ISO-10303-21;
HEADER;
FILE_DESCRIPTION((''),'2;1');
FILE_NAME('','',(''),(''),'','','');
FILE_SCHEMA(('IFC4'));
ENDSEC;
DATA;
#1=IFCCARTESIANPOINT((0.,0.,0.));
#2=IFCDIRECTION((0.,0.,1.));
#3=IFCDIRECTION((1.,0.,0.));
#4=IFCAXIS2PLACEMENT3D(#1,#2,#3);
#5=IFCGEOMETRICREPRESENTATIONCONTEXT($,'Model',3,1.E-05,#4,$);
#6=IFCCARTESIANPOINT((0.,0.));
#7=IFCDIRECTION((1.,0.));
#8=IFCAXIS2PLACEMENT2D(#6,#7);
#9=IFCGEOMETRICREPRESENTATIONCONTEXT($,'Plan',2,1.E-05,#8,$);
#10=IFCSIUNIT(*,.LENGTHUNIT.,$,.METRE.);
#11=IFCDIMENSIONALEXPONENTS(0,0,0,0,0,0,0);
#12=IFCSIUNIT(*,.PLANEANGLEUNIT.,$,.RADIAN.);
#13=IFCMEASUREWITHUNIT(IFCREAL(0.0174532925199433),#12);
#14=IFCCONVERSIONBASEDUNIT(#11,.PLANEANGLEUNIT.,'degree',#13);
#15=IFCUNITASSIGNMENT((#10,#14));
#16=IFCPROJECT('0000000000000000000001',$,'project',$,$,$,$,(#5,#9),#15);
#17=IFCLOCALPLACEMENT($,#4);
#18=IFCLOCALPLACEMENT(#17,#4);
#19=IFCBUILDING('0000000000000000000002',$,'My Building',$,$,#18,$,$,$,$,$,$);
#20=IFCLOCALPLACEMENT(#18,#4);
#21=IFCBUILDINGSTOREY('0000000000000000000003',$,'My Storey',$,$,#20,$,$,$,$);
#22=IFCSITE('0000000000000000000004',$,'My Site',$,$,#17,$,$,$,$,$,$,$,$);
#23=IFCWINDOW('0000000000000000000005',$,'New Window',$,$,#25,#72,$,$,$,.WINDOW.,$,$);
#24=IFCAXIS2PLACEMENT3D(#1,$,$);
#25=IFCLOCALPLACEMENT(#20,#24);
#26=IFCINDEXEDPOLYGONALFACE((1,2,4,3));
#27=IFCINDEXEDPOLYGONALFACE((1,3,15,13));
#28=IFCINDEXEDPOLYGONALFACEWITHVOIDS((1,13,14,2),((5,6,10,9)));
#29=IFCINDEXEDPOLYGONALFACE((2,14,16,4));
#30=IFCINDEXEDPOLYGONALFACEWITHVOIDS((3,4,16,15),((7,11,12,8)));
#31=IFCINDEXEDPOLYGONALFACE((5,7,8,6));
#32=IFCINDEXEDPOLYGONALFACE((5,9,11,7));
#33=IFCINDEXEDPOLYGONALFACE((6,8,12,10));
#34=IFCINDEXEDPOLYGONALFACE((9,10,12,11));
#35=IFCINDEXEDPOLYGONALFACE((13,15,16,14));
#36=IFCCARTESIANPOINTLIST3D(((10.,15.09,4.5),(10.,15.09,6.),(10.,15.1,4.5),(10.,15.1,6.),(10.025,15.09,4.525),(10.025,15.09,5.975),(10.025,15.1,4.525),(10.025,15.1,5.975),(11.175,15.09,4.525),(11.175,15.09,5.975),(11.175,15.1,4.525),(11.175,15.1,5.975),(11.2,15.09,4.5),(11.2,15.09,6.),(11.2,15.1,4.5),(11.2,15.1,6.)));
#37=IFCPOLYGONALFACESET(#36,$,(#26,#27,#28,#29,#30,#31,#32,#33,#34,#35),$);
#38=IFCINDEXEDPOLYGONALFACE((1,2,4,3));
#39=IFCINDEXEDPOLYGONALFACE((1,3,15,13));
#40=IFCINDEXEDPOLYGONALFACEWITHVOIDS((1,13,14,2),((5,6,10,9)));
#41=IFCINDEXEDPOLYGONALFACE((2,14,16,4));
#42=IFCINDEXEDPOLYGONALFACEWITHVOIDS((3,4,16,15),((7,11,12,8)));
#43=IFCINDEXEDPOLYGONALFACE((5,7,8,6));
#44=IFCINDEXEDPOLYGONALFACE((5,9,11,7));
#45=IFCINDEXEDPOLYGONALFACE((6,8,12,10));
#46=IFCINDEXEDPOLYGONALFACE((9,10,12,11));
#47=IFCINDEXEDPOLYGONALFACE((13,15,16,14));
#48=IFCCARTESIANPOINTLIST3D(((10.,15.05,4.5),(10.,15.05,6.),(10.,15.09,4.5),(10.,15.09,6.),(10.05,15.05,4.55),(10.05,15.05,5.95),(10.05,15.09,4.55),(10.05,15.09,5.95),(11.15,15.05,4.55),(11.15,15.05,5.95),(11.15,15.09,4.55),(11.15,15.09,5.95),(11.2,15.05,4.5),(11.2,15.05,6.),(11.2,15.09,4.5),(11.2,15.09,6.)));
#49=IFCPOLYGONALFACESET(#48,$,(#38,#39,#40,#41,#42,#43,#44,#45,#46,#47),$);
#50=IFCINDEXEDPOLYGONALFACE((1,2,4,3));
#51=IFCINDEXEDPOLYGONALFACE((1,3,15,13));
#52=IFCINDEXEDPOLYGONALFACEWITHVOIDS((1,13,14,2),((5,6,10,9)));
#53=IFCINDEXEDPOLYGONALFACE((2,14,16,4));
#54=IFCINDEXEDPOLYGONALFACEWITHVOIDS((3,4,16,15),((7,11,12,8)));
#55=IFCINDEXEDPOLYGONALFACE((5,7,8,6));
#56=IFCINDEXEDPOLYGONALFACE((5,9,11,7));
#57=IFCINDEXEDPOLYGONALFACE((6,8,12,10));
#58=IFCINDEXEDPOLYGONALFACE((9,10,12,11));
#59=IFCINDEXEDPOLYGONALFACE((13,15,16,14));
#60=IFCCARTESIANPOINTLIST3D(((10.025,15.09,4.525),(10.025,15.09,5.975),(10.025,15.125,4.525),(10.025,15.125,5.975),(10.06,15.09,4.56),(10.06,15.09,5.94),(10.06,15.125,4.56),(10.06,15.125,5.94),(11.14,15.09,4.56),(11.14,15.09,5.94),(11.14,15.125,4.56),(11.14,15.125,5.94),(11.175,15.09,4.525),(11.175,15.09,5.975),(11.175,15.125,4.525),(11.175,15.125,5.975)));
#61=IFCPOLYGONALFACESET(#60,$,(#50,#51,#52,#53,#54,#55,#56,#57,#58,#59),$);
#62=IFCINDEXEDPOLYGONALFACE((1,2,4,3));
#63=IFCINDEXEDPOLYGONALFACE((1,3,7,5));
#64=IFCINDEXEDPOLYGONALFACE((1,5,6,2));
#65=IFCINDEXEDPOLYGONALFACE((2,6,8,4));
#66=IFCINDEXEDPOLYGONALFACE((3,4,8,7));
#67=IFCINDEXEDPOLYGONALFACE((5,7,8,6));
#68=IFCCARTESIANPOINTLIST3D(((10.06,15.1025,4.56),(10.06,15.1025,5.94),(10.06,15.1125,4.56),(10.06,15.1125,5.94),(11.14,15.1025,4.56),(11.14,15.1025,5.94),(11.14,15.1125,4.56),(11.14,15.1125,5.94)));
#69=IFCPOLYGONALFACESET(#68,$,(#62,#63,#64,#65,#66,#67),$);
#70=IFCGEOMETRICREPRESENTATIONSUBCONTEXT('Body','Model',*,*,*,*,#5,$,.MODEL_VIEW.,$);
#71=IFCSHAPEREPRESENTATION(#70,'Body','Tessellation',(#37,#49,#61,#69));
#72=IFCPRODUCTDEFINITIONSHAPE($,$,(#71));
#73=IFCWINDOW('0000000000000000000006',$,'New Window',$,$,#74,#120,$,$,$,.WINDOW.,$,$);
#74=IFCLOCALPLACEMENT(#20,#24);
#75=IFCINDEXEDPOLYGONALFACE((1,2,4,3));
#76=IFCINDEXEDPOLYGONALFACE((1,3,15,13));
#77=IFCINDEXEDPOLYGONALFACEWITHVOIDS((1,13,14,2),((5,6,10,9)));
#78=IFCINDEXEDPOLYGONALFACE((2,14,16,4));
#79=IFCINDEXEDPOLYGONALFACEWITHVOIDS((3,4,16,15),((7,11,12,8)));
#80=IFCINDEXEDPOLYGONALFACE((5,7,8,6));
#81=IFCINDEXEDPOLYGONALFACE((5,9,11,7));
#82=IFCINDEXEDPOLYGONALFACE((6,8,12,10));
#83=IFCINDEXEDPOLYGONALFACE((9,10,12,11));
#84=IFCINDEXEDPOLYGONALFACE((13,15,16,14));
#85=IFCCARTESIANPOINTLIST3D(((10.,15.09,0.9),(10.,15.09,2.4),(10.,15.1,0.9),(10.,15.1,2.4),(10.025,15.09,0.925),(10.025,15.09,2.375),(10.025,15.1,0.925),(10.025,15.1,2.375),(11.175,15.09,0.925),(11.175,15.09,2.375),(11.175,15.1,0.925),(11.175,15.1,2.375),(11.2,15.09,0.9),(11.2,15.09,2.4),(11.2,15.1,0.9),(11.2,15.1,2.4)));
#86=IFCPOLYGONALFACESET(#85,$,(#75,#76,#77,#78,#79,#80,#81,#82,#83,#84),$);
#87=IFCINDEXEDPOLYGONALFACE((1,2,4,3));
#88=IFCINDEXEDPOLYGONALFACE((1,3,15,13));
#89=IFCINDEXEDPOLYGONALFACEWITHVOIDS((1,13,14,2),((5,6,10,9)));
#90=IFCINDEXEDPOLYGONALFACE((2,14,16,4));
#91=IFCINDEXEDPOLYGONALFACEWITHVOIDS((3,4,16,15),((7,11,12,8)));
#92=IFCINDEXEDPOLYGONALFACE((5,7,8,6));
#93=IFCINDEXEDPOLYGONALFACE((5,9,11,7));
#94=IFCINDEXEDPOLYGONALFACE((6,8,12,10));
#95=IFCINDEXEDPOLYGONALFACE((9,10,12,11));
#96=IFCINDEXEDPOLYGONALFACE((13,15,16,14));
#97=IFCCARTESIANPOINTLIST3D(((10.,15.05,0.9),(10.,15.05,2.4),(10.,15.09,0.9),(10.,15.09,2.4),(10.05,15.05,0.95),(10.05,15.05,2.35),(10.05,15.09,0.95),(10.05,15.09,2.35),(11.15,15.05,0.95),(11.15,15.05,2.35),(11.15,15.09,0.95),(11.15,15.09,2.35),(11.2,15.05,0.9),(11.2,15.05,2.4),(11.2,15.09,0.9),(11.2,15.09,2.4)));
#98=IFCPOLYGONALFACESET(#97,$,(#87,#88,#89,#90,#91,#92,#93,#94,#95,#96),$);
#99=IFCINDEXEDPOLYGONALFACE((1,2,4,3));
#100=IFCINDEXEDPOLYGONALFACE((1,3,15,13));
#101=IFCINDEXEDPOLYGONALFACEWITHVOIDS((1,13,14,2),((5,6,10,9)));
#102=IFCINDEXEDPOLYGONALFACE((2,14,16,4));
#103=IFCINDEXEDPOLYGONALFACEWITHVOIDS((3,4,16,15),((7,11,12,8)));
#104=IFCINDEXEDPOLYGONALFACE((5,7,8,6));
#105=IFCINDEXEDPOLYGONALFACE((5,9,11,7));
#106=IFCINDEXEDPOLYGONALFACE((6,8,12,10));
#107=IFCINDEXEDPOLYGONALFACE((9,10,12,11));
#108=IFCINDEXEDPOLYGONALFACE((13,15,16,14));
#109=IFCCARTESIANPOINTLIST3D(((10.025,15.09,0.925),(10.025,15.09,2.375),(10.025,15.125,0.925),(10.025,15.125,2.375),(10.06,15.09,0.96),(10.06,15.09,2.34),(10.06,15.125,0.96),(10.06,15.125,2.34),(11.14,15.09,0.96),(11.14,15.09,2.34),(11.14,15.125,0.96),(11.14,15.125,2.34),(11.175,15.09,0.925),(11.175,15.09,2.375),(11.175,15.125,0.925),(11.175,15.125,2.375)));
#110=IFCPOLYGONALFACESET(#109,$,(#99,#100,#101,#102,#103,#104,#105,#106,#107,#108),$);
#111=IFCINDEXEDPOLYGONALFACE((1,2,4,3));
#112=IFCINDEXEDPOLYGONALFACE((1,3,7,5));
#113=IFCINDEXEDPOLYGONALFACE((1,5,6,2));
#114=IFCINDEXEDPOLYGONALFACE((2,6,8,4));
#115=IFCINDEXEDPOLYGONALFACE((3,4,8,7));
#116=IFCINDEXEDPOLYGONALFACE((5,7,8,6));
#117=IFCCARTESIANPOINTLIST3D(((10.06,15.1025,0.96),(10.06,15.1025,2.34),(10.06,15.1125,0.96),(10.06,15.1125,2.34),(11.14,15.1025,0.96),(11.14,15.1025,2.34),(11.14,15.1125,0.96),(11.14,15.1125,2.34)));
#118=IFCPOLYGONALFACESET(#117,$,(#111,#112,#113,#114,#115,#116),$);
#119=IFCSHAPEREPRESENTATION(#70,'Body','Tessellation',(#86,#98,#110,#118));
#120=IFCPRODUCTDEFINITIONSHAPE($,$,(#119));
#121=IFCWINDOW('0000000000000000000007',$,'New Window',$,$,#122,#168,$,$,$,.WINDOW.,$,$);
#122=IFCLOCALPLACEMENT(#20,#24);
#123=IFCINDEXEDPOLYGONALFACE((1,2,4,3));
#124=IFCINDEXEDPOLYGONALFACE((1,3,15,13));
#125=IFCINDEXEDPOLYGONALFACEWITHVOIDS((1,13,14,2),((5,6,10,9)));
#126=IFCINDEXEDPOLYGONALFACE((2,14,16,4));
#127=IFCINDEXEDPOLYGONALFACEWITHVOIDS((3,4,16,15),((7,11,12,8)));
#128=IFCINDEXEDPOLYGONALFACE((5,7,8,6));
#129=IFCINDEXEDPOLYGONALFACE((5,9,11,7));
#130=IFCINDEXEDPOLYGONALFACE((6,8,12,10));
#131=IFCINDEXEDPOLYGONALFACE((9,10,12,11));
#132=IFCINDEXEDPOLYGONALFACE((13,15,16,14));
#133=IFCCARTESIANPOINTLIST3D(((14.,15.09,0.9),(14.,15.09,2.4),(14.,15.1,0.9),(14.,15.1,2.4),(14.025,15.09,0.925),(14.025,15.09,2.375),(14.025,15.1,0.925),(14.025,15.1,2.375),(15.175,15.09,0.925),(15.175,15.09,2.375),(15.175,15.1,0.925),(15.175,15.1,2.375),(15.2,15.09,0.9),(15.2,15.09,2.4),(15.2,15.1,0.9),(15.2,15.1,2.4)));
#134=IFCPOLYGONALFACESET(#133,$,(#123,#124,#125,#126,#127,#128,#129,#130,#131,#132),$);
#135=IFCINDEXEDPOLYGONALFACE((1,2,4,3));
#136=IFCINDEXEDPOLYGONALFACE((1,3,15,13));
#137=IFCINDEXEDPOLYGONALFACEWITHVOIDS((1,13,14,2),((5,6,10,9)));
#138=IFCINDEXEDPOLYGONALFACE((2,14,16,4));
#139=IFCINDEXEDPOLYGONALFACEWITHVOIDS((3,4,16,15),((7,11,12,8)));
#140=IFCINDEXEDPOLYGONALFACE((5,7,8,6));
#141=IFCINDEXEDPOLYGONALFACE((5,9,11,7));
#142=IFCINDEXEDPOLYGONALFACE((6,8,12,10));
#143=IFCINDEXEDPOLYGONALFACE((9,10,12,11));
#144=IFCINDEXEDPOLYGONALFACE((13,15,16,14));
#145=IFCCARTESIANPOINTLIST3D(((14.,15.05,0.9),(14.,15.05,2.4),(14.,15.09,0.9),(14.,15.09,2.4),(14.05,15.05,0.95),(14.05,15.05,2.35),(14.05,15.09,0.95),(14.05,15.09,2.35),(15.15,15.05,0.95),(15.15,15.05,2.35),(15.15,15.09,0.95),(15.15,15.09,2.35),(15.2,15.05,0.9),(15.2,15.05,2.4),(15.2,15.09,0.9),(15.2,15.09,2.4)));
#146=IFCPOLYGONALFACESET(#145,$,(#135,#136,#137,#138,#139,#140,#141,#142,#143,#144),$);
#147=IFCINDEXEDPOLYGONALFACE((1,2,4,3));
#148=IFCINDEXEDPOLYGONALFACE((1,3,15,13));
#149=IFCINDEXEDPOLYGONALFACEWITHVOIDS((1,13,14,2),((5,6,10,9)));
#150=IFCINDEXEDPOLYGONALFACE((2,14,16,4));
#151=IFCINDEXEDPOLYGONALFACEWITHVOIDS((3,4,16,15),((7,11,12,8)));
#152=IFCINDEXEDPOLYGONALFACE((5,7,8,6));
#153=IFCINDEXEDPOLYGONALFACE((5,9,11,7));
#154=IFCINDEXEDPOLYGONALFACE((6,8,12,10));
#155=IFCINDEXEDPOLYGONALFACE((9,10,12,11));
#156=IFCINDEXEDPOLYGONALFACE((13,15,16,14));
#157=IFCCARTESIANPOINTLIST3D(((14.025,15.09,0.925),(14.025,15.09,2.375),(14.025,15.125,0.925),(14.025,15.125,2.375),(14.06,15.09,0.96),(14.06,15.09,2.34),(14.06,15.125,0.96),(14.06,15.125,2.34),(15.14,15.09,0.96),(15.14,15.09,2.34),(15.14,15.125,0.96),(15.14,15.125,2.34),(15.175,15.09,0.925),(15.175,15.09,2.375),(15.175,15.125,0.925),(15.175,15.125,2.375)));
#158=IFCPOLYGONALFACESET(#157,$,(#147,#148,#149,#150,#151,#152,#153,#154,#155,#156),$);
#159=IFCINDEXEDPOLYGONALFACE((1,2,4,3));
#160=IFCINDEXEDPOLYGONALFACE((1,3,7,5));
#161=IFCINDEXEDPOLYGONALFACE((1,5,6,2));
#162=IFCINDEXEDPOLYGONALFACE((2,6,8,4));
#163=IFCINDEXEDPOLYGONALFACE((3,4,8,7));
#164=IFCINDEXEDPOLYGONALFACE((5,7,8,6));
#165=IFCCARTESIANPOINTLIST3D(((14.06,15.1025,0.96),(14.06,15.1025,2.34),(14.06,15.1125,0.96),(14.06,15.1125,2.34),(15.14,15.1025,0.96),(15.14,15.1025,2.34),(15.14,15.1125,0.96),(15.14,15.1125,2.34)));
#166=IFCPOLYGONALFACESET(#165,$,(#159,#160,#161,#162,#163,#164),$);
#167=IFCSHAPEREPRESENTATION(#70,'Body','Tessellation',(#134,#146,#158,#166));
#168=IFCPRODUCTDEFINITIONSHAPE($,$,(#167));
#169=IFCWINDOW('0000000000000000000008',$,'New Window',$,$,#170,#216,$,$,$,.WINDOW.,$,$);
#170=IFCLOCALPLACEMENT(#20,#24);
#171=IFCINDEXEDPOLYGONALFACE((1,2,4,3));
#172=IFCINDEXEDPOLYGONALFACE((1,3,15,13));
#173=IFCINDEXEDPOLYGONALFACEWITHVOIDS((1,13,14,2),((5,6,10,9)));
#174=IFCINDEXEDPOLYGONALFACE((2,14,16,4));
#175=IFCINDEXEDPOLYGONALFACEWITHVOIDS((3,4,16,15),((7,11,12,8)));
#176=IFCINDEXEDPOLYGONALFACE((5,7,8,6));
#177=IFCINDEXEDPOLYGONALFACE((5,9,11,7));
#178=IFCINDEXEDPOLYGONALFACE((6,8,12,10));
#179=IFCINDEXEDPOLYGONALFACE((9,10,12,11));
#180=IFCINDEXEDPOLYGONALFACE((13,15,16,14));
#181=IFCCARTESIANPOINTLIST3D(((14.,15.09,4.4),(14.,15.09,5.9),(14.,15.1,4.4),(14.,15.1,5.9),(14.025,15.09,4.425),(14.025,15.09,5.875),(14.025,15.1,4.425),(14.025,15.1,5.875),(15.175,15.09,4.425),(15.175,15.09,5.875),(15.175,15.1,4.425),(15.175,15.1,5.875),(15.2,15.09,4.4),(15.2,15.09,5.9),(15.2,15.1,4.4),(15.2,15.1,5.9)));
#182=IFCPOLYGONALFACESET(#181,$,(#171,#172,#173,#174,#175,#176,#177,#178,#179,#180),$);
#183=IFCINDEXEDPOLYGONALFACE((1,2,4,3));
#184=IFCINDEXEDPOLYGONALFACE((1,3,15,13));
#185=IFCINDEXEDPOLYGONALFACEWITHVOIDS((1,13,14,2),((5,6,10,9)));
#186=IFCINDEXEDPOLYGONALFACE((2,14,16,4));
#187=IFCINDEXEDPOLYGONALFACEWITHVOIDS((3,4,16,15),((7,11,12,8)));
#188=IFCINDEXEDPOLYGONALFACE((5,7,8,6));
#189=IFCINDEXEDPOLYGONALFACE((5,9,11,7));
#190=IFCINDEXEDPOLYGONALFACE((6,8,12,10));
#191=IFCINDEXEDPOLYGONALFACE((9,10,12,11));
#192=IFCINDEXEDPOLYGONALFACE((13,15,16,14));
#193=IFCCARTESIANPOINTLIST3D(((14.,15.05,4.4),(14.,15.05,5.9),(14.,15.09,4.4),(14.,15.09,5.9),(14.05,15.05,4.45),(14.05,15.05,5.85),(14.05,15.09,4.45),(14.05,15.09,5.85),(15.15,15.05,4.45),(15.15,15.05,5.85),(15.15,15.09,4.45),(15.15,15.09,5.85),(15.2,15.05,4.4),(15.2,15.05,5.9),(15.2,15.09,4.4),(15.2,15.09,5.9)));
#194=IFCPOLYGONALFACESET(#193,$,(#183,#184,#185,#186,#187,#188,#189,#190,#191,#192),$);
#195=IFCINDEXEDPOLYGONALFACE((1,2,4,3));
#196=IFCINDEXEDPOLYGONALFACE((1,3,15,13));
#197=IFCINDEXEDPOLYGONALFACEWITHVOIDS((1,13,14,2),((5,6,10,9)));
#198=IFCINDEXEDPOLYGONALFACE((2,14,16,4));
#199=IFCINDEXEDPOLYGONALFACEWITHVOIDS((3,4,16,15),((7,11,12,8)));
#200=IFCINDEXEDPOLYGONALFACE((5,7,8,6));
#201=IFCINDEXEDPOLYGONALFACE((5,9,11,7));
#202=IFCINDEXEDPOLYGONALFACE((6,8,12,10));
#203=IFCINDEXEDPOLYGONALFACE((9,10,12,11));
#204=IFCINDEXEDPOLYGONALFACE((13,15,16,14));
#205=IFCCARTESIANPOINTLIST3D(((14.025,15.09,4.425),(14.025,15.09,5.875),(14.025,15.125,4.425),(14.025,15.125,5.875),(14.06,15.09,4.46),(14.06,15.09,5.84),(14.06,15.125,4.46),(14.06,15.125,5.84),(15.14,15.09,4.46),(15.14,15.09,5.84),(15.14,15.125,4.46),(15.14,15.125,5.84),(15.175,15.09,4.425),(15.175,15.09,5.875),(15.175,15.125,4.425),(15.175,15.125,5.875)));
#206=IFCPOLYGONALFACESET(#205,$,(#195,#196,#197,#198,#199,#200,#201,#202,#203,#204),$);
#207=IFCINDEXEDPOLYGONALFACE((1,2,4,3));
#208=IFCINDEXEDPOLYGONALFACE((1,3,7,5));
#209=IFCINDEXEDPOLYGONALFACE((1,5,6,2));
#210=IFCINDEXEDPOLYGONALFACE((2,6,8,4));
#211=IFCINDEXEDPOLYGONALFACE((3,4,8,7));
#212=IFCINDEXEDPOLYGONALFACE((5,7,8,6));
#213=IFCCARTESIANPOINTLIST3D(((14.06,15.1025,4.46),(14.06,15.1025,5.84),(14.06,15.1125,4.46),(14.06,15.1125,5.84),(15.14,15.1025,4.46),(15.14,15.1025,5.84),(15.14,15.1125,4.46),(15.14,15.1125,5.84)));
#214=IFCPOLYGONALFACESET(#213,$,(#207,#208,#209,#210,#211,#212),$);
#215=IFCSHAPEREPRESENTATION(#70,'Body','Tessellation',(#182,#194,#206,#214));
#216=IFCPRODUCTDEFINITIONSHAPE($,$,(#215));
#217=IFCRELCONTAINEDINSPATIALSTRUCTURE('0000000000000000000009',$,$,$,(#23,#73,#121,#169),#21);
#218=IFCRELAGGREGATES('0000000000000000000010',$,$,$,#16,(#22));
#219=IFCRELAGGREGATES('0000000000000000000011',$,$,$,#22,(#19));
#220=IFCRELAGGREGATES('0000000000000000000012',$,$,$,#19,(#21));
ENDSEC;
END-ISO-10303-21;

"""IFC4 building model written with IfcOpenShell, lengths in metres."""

from ifc_helpers import new_model, entity, si_unit, converted_unit, frame, origin_with_axes, origin_2d_with_axis, place, context, subcontext, project, spatial, line, indexed_curve, outline, extrude, element, save


model = new_model("IFC4")

# Units and contexts
model_context = context("Model", 3, precision=1e-05, world=origin_with_axes())
plan_context = context("Plan", 2, precision=1e-05, world=origin_2d_with_axis())
body_context = subcontext(model_context, "Body", "Model", "MODEL_VIEW")
ifc_project = project(units=[si_unit("LENGTHUNIT", "METRE"), converted_unit("PLANEANGLEUNIT", "degree", entity("IfcReal", 0.0174532925199433), si_unit("PLANEANGLEUNIT", "RADIAN"), dimensions=[0, 0, 0, 0, 0, 0, 0])], contexts=[model_context, plan_context])

# Site, building, storey
site_placement = place(None, origin_with_axes())
site = spatial("IfcSite", under=ifc_project, at=site_placement, Name="My Site")
building_placement = place(site_placement, origin_with_axes())
building = spatial("IfcBuilding", under=site, at=building_placement, Name="My Building")
storey_placement = place(building_placement, origin_with_axes())
storey = spatial("IfcBuildingStorey", under=building, at=storey_placement, Name="My Storey")

# Windows
for number, where, z_axis, x_axis, name in (
    (1, (10.0, 15.0, 4.5), (0.0, 0.0, 1.0), (1.0, 0.0, 0.0), "New Window"),
    (2, (10.0, 15.0, 0.9), (0.0, 0.0, 1.0), (1.0, 0.0, 0.0), "New Window"),
    (3, (14.0, 15.0, 0.9), (0.0, 0.0, 1.0), (1.0, 0.0, 0.0), "New Window"),
    (4, (14.0, 15.0, 4.4), (0.0, 0.0, 1.0), (1.0, 0.0, 0.0), "New Window"),
):
    element("IfcWindow", number, at=place(storey_placement, frame(where, z_axis=z_axis, x_axis=x_axis)), inside=storey, Name=name, PredefinedType="WINDOW", context=body_context, shape_type="SweptSolid", body=[
        extrude(outline(indexed_curve([(0.0, 0.0), (1.2, 0.0), (1.2, 1.5), (0.0, 1.5)], segments=[line(1, 2, 3, 4, 1)]), holes=[indexed_curve([(0.025, 0.025), (1.175, 0.025), (1.175, 1.475), (0.025, 1.475)], segments=[line(1, 2, 3, 4, 1)])]), frame((0.0, 0.09, 0.0), z_axis=(0.0, -1.0, 0.0), x_axis=(1.0, 0.0, 0.0)), (0.0, 0.0, -1.0), 0.01),
        extrude(outline(indexed_curve([(0.0, 0.0), (1.2, 0.0), (1.2, 1.5), (0.0, 1.5)], segments=[line(1, 2, 3, 4, 1)]), holes=[indexed_curve([(0.05, 0.05), (1.15, 0.05), (1.15, 1.45), (0.05, 1.45)], segments=[line(1, 2, 3, 4, 1)])]), frame((0.0, 0.05, 0.0), z_axis=(0.0, -1.0, 0.0), x_axis=(1.0, 0.0, 0.0)), (0.0, 0.0, -1.0), 0.04),
        extrude(outline(indexed_curve([(0.0, 0.0), (1.15, 0.0), (1.15, 1.45), (0.0, 1.45)], segments=[line(1, 2, 3, 4, 1)]), holes=[indexed_curve([(0.035, 0.035), (1.115, 0.035), (1.115, 1.415), (0.035, 1.415)], segments=[line(1, 2, 3, 4, 1)])]), frame((0.025, 0.09, 0.025), z_axis=(0.0, -1.0, 0.0), x_axis=(1.0, 0.0, 0.0)), (0.0, 0.0, -1.0), 0.035),
        extrude(outline(indexed_curve([(0.035, 0.035), (1.115, 0.035), (1.115, 1.415), (0.035, 1.415)], segments=[line(1, 2, 3, 4, 1)])), frame((0.025, 0.1025, 0.025), z_axis=(0.0, -1.0, 0.0), x_axis=(1.0, 0.0, 0.0)), (0.0, 0.0, -1.0), 0.01),
    ])

save(model, "model.ifc")
